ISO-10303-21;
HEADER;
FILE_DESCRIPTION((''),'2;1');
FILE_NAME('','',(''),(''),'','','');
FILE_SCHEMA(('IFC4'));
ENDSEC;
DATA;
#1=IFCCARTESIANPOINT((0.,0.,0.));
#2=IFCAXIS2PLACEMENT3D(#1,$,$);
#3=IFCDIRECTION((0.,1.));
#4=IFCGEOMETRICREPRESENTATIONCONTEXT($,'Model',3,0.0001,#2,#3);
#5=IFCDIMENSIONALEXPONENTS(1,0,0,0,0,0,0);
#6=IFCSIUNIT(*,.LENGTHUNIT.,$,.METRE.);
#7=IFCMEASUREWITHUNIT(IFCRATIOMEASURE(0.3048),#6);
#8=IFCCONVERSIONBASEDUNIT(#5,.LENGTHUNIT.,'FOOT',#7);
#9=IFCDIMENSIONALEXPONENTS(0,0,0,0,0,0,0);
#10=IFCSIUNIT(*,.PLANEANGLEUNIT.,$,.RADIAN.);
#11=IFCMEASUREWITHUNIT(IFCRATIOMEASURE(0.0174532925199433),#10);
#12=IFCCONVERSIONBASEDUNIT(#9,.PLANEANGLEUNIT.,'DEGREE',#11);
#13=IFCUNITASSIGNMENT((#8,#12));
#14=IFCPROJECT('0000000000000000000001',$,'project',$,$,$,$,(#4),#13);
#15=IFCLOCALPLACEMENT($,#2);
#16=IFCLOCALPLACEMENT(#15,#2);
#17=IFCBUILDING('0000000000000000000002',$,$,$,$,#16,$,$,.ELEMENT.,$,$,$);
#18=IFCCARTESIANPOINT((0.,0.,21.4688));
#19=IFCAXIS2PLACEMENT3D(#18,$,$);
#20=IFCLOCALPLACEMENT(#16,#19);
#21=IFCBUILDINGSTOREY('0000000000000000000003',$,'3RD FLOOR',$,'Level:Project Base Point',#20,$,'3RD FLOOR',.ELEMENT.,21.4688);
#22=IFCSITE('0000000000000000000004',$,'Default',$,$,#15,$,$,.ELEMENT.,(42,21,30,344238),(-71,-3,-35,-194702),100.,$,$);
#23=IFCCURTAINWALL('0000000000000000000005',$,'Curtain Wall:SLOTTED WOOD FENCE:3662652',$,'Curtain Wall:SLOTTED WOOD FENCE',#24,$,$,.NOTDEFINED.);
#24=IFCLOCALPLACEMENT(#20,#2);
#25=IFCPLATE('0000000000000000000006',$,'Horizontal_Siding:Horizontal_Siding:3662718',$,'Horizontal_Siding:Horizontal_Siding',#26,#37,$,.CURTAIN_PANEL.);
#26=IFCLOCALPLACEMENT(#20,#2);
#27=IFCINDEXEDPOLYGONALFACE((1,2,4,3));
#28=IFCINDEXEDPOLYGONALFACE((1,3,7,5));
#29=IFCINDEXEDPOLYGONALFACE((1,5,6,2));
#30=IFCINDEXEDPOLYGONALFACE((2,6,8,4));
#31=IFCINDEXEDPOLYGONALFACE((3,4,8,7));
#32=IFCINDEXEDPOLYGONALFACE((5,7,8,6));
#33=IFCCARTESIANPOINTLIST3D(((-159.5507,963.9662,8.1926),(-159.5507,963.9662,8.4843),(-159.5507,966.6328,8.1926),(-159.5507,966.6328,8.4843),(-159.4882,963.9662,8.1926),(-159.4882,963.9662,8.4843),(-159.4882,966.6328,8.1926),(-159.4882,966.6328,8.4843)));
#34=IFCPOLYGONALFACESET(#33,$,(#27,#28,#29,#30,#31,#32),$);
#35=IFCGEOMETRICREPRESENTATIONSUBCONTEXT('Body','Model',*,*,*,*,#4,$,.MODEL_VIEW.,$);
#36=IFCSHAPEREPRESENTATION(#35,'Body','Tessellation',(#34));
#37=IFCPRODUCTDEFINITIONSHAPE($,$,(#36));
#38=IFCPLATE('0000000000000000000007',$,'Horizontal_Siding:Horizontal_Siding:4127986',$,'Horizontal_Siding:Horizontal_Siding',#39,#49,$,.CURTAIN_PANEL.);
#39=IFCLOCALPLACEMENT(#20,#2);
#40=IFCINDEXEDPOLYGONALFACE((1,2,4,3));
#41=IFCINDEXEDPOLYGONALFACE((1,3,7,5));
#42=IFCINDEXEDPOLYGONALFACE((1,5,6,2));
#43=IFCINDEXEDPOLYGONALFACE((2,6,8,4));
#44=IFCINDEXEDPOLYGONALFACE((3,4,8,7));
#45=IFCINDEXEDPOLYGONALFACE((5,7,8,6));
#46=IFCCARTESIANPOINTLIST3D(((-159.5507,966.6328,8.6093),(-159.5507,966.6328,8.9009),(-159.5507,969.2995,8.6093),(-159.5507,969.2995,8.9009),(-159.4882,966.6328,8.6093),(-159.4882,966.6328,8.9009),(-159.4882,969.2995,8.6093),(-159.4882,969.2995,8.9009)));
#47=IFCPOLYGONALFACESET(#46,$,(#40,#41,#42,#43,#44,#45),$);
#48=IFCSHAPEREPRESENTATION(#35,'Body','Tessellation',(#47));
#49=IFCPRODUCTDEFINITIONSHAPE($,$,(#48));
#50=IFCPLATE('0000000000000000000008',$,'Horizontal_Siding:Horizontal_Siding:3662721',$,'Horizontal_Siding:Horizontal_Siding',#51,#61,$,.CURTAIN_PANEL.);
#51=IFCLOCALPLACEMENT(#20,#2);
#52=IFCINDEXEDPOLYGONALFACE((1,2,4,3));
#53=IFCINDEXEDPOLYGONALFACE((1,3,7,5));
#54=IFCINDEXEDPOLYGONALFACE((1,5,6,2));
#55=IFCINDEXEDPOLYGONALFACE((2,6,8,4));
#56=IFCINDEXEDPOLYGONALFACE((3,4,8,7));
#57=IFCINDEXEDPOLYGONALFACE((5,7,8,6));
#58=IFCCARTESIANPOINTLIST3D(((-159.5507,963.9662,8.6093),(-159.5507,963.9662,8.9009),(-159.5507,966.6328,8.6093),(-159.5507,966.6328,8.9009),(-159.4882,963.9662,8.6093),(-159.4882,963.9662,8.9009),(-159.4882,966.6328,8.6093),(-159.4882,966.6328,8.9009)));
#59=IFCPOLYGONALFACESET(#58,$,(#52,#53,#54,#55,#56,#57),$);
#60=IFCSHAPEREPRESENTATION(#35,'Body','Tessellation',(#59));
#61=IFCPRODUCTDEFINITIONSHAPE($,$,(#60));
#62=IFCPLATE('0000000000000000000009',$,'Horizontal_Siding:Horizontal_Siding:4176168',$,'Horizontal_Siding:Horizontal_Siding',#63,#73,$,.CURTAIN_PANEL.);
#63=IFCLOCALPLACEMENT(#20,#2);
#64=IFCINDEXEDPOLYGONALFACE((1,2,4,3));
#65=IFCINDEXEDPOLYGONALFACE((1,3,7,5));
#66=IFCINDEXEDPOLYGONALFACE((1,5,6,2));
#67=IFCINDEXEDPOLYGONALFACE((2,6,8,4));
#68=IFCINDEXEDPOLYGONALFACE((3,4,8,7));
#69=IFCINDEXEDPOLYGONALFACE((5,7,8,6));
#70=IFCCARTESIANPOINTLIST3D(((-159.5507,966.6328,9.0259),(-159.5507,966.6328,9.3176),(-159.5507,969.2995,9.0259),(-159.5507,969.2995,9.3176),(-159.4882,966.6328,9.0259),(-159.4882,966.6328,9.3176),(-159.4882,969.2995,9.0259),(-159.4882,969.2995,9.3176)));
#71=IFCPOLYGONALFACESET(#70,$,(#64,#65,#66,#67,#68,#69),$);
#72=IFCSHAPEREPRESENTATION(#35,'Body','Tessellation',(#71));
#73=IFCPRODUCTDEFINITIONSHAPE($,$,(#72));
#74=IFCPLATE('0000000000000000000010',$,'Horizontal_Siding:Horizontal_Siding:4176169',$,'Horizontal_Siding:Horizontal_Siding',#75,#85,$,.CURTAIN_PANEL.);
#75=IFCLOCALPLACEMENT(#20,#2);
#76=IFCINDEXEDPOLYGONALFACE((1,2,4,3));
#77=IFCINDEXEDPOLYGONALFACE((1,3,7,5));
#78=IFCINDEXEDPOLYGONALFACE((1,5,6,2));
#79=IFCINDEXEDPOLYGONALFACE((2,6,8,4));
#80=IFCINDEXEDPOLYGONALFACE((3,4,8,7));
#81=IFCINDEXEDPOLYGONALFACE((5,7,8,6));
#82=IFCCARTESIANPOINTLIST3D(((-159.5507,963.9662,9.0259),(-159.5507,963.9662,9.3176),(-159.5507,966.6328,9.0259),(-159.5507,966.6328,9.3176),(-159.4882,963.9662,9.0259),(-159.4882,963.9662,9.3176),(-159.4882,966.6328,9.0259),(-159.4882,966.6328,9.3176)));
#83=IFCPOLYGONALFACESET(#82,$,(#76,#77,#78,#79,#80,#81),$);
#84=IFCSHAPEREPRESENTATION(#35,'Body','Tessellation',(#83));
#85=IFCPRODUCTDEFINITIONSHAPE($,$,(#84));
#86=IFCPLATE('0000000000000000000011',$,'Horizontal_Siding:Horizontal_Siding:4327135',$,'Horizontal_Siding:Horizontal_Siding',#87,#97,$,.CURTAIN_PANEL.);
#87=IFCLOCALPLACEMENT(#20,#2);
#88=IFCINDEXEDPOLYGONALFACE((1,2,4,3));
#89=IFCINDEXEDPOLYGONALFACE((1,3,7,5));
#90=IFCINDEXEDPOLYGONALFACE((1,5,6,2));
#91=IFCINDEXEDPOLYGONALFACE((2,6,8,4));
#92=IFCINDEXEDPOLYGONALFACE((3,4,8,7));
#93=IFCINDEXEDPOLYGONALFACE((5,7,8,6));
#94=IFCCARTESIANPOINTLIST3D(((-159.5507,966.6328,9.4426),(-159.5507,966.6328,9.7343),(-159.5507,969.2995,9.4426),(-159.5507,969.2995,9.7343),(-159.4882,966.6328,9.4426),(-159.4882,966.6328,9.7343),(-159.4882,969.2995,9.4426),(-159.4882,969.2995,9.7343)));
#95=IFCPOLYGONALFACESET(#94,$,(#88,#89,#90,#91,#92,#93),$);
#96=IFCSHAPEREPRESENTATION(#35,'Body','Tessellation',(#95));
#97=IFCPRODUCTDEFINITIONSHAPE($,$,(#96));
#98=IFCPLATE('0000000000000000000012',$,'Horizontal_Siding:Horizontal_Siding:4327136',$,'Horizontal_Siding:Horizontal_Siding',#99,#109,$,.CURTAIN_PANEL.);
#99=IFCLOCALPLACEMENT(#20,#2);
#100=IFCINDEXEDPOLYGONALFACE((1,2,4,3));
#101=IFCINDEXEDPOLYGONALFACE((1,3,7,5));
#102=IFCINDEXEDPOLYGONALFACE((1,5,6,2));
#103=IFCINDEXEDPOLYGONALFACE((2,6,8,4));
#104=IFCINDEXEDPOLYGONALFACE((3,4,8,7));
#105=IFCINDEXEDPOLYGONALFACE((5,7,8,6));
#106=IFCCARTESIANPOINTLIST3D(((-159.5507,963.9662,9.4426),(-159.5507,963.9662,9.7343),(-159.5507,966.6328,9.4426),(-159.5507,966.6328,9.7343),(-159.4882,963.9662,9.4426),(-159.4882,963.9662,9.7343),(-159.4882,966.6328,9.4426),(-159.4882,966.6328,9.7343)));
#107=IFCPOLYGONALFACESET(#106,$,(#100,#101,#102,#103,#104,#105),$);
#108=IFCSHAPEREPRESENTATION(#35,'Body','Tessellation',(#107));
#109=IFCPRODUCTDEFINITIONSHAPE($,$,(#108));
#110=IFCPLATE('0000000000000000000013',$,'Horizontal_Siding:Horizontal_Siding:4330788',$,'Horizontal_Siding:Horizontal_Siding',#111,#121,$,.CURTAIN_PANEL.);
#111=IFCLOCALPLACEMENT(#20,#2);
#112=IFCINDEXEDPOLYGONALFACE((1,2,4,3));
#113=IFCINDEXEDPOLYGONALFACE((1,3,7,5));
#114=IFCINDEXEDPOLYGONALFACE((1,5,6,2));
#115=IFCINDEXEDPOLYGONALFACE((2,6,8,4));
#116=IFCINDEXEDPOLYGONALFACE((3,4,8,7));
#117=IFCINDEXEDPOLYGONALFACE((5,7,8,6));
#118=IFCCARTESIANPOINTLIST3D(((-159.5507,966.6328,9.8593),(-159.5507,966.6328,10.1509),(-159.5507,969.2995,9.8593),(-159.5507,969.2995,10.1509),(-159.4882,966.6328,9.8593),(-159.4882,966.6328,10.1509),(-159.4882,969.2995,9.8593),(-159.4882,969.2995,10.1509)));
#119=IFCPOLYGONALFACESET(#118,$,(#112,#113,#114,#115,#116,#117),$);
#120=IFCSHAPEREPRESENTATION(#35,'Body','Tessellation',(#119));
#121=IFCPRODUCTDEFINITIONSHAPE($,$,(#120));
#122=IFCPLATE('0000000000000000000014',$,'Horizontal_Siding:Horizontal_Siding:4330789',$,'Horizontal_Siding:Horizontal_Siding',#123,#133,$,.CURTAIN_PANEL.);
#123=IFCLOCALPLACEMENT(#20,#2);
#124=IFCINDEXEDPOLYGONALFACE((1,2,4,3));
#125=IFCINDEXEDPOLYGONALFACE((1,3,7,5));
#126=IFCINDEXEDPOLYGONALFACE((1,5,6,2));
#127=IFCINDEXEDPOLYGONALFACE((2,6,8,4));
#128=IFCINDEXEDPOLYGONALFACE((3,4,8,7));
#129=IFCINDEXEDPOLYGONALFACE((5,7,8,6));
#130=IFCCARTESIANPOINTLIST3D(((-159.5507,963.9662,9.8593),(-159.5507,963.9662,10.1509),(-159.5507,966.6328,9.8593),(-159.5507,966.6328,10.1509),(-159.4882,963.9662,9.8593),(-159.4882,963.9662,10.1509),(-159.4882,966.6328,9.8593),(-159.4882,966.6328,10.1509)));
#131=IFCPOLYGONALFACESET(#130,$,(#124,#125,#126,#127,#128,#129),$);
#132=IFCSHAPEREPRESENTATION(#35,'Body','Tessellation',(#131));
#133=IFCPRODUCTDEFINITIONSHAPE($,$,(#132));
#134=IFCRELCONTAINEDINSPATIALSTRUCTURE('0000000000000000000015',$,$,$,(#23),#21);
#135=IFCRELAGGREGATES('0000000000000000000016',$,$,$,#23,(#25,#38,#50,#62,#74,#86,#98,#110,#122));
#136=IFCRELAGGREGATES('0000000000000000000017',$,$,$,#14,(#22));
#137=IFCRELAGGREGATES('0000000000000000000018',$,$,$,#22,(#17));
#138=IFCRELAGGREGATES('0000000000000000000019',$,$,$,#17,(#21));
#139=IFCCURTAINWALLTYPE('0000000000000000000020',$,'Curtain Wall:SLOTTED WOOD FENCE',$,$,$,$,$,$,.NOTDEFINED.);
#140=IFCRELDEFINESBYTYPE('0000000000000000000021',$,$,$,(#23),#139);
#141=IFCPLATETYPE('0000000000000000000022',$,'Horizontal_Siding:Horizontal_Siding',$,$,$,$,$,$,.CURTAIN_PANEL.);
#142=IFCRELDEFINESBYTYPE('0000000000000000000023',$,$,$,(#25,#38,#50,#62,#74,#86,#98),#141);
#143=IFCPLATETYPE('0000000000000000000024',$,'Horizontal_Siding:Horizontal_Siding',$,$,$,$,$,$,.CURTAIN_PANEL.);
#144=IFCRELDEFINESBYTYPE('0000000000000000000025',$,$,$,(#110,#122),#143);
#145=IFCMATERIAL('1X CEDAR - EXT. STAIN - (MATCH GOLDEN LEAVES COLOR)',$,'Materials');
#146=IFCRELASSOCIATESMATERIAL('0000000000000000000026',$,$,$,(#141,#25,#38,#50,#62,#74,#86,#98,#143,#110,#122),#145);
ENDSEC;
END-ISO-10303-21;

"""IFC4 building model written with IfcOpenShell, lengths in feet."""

from ifc_helpers import new_model, entity, si_unit, converted_unit, direction, frame, origin, origin_2d_with_axis, place, context, subcontext, project, spatial, rectangle, extrude, source, transform, mapped, material, type_object, type_shapes, element, aggregate, save


model = new_model("IFC4")

# Units and contexts
model_context = context("Model", 3, precision=0.0001, world=origin(), true_north=direction((0.0, 1.0)))
body_context = subcontext(model_context, "Body", "Model", "MODEL_VIEW")
ifc_project = project(units=[converted_unit("LENGTHUNIT", "FOOT", entity("IfcRatioMeasure", 0.3048), si_unit("LENGTHUNIT", "METRE"), dimensions=[1, 0, 0, 0, 0, 0, 0]), converted_unit("PLANEANGLEUNIT", "DEGREE", entity("IfcRatioMeasure", 0.0174532925199433), si_unit("PLANEANGLEUNIT", "RADIAN"), dimensions=[0, 0, 0, 0, 0, 0, 0])], contexts=[model_context])

# Site, building, storey
site_placement = place(None, origin())
site = spatial("IfcSite", under=ifc_project, at=site_placement, Name="Default", CompositionType="ELEMENT", RefLatitude=(42, 21, 30, 344238), RefLongitude=(-71, -3, -35, -194702), RefElevation=100.0)
building_placement = place(site_placement, origin())
building = spatial("IfcBuilding", under=site, at=building_placement, CompositionType="ELEMENT")
storey_placement = place(building_placement, frame((0.0, 0.0, 21.4688)))
storey = spatial("IfcBuildingStorey", under=building, at=storey_placement, Name="3RD FLOOR", ObjectType="Level:Project Base Point", LongName="3RD FLOOR", CompositionType="ELEMENT", Elevation=21.4688)

# Curtain wall, plates
curtain_wall_type = type_object("IfcCurtainWallType", Name="Curtain Wall:SLOTTED WOOD FENCE", PredefinedType="NOTDEFINED")
curtain_wall_placement = place(storey_placement, frame((0.0, 0.0, -21.4688)))
curtain_wall = element("IfcCurtainWall", 1, at=curtain_wall_placement, inside=storey, type_object=curtain_wall_type, Name="Curtain Wall:SLOTTED WOOD FENCE:3662652", ObjectType="Curtain Wall:SLOTTED WOOD FENCE", PredefinedType="NOTDEFINED")
ifc_material_1 = material(Name="1X CEDAR - EXT. STAIN - (MATCH GOLDEN LEAVES COLOR)", Category="Materials")
plate_type_1 = type_object("IfcPlateType", Name="Horizontal_Siding:Horizontal_Siding", PredefinedType="CURTAIN_PANEL", material=ifc_material_1)
shared_shape_1 = source(origin(), body_context, "Body", "SweptSolid", [
    extrude(rectangle(XDim=2.6667, YDim=0.0625, at=origin_2d_with_axis()), frame((1.3333, 0.0312, 0.0), z_axis=(0.0, 0.0, 1.0), x_axis=(-1.0, 0.0, 0.0)), (0.0, 0.0, 1.0), 0.2917),
])
type_shapes(plate_type_1, [shared_shape_1])
plate_1_placement = place(curtain_wall_placement, frame((-159.5507, 966.6328, 29.6613), z_axis=(0.0, 0.0, 1.0), x_axis=(0.0, -1.0, 0.0)))
plate_1 = element("IfcPlate", 2, at=plate_1_placement, type_object=plate_type_1, material=ifc_material_1, Name="Horizontal_Siding:Horizontal_Siding:3662718", ObjectType="Horizontal_Siding:Horizontal_Siding", PredefinedType="CURTAIN_PANEL", context=body_context, shape_type="MappedRepresentation", body=[
    mapped(shared_shape_1, transform((0.0, 0.0, 0.0), scale=1.0)),
])
plate_2_placement = place(curtain_wall_placement, frame((-159.5507, 969.2995, 30.078), z_axis=(0.0, 0.0, 1.0), x_axis=(0.0, -1.0, 0.0)))
plate_2 = element("IfcPlate", 3, at=plate_2_placement, type_object=plate_type_1, material=ifc_material_1, Name="Horizontal_Siding:Horizontal_Siding:4127986", ObjectType="Horizontal_Siding:Horizontal_Siding", PredefinedType="CURTAIN_PANEL", context=body_context, shape_type="MappedRepresentation", body=[
    mapped(shared_shape_1, transform((0.0, 0.0, 0.0), scale=1.0)),
])
plate_3_placement = place(curtain_wall_placement, frame((-159.5507, 966.6328, 30.078), z_axis=(0.0, 0.0, 1.0), x_axis=(0.0, -1.0, 0.0)))
plate_3 = element("IfcPlate", 4, at=plate_3_placement, type_object=plate_type_1, material=ifc_material_1, Name="Horizontal_Siding:Horizontal_Siding:3662721", ObjectType="Horizontal_Siding:Horizontal_Siding", PredefinedType="CURTAIN_PANEL", context=body_context, shape_type="MappedRepresentation", body=[
    mapped(shared_shape_1, transform((0.0, 0.0, 0.0), scale=1.0)),
])
plate_4_placement = place(curtain_wall_placement, frame((-159.5507, 969.2995, 30.4947), z_axis=(0.0, 0.0, 1.0), x_axis=(0.0, -1.0, 0.0)))
plate_4 = element("IfcPlate", 5, at=plate_4_placement, type_object=plate_type_1, material=ifc_material_1, Name="Horizontal_Siding:Horizontal_Siding:4176168", ObjectType="Horizontal_Siding:Horizontal_Siding", PredefinedType="CURTAIN_PANEL", context=body_context, shape_type="MappedRepresentation", body=[
    mapped(shared_shape_1, transform((0.0, 0.0, 0.0), scale=1.0)),
])
plate_5_placement = place(curtain_wall_placement, frame((-159.5507, 966.6328, 30.4947), z_axis=(0.0, 0.0, 1.0), x_axis=(0.0, -1.0, 0.0)))
plate_5 = element("IfcPlate", 6, at=plate_5_placement, type_object=plate_type_1, material=ifc_material_1, Name="Horizontal_Siding:Horizontal_Siding:4176169", ObjectType="Horizontal_Siding:Horizontal_Siding", PredefinedType="CURTAIN_PANEL", context=body_context, shape_type="MappedRepresentation", body=[
    mapped(shared_shape_1, transform((0.0, 0.0, 0.0), scale=1.0)),
])
plate_6_placement = place(curtain_wall_placement, frame((-159.5507, 969.2995, 30.9113), z_axis=(0.0, 0.0, 1.0), x_axis=(0.0, -1.0, 0.0)))
plate_6 = element("IfcPlate", 7, at=plate_6_placement, type_object=plate_type_1, material=ifc_material_1, Name="Horizontal_Siding:Horizontal_Siding:4327135", ObjectType="Horizontal_Siding:Horizontal_Siding", PredefinedType="CURTAIN_PANEL", context=body_context, shape_type="MappedRepresentation", body=[
    mapped(shared_shape_1, transform((0.0, 0.0, 0.0), scale=1.0)),
])
plate_7_placement = place(curtain_wall_placement, frame((-159.5507, 966.6328, 30.9113), z_axis=(0.0, 0.0, 1.0), x_axis=(0.0, -1.0, 0.0)))
plate_7 = element("IfcPlate", 8, at=plate_7_placement, type_object=plate_type_1, material=ifc_material_1, Name="Horizontal_Siding:Horizontal_Siding:4327136", ObjectType="Horizontal_Siding:Horizontal_Siding", PredefinedType="CURTAIN_PANEL", context=body_context, shape_type="MappedRepresentation", body=[
    mapped(shared_shape_1, transform((0.0, 0.0, 0.0), scale=1.0)),
])
plate_type_2 = type_object("IfcPlateType", Name="Horizontal_Siding:Horizontal_Siding", PredefinedType="CURTAIN_PANEL", material=ifc_material_1)
shared_shape_2 = source(origin(), body_context, "Body", "SweptSolid", [
    extrude(rectangle(XDim=2.6667, YDim=0.0625, at=origin_2d_with_axis()), frame((1.3333, 0.0312, 0.0), z_axis=(0.0, 0.0, 1.0), x_axis=(-1.0, 0.0, 0.0)), (0.0, 0.0, 1.0), 0.2917),
])
type_shapes(plate_type_2, [shared_shape_2])
plate_8_placement = place(curtain_wall_placement, frame((-159.5507, 969.2995, 31.328), z_axis=(0.0, 0.0, 1.0), x_axis=(0.0, -1.0, 0.0)))
plate_8 = element("IfcPlate", 9, at=plate_8_placement, type_object=plate_type_2, material=ifc_material_1, Name="Horizontal_Siding:Horizontal_Siding:4330788", ObjectType="Horizontal_Siding:Horizontal_Siding", PredefinedType="CURTAIN_PANEL", context=body_context, shape_type="MappedRepresentation", body=[
    mapped(shared_shape_2, transform((0.0, 0.0, 0.0), scale=1.0)),
])
plate_9_placement = place(curtain_wall_placement, frame((-159.5507, 966.6328, 31.328), z_axis=(0.0, 0.0, 1.0), x_axis=(0.0, -1.0, 0.0)))
plate_9 = element("IfcPlate", 10, at=plate_9_placement, type_object=plate_type_2, material=ifc_material_1, Name="Horizontal_Siding:Horizontal_Siding:4330789", ObjectType="Horizontal_Siding:Horizontal_Siding", PredefinedType="CURTAIN_PANEL", context=body_context, shape_type="MappedRepresentation", body=[
    mapped(shared_shape_2, transform((0.0, 0.0, 0.0), scale=1.0)),
])
aggregate(curtain_wall, [plate_1, plate_2, plate_3, plate_4, plate_5, plate_6, plate_7, plate_8, plate_9])

save(model, "model.ifc")
